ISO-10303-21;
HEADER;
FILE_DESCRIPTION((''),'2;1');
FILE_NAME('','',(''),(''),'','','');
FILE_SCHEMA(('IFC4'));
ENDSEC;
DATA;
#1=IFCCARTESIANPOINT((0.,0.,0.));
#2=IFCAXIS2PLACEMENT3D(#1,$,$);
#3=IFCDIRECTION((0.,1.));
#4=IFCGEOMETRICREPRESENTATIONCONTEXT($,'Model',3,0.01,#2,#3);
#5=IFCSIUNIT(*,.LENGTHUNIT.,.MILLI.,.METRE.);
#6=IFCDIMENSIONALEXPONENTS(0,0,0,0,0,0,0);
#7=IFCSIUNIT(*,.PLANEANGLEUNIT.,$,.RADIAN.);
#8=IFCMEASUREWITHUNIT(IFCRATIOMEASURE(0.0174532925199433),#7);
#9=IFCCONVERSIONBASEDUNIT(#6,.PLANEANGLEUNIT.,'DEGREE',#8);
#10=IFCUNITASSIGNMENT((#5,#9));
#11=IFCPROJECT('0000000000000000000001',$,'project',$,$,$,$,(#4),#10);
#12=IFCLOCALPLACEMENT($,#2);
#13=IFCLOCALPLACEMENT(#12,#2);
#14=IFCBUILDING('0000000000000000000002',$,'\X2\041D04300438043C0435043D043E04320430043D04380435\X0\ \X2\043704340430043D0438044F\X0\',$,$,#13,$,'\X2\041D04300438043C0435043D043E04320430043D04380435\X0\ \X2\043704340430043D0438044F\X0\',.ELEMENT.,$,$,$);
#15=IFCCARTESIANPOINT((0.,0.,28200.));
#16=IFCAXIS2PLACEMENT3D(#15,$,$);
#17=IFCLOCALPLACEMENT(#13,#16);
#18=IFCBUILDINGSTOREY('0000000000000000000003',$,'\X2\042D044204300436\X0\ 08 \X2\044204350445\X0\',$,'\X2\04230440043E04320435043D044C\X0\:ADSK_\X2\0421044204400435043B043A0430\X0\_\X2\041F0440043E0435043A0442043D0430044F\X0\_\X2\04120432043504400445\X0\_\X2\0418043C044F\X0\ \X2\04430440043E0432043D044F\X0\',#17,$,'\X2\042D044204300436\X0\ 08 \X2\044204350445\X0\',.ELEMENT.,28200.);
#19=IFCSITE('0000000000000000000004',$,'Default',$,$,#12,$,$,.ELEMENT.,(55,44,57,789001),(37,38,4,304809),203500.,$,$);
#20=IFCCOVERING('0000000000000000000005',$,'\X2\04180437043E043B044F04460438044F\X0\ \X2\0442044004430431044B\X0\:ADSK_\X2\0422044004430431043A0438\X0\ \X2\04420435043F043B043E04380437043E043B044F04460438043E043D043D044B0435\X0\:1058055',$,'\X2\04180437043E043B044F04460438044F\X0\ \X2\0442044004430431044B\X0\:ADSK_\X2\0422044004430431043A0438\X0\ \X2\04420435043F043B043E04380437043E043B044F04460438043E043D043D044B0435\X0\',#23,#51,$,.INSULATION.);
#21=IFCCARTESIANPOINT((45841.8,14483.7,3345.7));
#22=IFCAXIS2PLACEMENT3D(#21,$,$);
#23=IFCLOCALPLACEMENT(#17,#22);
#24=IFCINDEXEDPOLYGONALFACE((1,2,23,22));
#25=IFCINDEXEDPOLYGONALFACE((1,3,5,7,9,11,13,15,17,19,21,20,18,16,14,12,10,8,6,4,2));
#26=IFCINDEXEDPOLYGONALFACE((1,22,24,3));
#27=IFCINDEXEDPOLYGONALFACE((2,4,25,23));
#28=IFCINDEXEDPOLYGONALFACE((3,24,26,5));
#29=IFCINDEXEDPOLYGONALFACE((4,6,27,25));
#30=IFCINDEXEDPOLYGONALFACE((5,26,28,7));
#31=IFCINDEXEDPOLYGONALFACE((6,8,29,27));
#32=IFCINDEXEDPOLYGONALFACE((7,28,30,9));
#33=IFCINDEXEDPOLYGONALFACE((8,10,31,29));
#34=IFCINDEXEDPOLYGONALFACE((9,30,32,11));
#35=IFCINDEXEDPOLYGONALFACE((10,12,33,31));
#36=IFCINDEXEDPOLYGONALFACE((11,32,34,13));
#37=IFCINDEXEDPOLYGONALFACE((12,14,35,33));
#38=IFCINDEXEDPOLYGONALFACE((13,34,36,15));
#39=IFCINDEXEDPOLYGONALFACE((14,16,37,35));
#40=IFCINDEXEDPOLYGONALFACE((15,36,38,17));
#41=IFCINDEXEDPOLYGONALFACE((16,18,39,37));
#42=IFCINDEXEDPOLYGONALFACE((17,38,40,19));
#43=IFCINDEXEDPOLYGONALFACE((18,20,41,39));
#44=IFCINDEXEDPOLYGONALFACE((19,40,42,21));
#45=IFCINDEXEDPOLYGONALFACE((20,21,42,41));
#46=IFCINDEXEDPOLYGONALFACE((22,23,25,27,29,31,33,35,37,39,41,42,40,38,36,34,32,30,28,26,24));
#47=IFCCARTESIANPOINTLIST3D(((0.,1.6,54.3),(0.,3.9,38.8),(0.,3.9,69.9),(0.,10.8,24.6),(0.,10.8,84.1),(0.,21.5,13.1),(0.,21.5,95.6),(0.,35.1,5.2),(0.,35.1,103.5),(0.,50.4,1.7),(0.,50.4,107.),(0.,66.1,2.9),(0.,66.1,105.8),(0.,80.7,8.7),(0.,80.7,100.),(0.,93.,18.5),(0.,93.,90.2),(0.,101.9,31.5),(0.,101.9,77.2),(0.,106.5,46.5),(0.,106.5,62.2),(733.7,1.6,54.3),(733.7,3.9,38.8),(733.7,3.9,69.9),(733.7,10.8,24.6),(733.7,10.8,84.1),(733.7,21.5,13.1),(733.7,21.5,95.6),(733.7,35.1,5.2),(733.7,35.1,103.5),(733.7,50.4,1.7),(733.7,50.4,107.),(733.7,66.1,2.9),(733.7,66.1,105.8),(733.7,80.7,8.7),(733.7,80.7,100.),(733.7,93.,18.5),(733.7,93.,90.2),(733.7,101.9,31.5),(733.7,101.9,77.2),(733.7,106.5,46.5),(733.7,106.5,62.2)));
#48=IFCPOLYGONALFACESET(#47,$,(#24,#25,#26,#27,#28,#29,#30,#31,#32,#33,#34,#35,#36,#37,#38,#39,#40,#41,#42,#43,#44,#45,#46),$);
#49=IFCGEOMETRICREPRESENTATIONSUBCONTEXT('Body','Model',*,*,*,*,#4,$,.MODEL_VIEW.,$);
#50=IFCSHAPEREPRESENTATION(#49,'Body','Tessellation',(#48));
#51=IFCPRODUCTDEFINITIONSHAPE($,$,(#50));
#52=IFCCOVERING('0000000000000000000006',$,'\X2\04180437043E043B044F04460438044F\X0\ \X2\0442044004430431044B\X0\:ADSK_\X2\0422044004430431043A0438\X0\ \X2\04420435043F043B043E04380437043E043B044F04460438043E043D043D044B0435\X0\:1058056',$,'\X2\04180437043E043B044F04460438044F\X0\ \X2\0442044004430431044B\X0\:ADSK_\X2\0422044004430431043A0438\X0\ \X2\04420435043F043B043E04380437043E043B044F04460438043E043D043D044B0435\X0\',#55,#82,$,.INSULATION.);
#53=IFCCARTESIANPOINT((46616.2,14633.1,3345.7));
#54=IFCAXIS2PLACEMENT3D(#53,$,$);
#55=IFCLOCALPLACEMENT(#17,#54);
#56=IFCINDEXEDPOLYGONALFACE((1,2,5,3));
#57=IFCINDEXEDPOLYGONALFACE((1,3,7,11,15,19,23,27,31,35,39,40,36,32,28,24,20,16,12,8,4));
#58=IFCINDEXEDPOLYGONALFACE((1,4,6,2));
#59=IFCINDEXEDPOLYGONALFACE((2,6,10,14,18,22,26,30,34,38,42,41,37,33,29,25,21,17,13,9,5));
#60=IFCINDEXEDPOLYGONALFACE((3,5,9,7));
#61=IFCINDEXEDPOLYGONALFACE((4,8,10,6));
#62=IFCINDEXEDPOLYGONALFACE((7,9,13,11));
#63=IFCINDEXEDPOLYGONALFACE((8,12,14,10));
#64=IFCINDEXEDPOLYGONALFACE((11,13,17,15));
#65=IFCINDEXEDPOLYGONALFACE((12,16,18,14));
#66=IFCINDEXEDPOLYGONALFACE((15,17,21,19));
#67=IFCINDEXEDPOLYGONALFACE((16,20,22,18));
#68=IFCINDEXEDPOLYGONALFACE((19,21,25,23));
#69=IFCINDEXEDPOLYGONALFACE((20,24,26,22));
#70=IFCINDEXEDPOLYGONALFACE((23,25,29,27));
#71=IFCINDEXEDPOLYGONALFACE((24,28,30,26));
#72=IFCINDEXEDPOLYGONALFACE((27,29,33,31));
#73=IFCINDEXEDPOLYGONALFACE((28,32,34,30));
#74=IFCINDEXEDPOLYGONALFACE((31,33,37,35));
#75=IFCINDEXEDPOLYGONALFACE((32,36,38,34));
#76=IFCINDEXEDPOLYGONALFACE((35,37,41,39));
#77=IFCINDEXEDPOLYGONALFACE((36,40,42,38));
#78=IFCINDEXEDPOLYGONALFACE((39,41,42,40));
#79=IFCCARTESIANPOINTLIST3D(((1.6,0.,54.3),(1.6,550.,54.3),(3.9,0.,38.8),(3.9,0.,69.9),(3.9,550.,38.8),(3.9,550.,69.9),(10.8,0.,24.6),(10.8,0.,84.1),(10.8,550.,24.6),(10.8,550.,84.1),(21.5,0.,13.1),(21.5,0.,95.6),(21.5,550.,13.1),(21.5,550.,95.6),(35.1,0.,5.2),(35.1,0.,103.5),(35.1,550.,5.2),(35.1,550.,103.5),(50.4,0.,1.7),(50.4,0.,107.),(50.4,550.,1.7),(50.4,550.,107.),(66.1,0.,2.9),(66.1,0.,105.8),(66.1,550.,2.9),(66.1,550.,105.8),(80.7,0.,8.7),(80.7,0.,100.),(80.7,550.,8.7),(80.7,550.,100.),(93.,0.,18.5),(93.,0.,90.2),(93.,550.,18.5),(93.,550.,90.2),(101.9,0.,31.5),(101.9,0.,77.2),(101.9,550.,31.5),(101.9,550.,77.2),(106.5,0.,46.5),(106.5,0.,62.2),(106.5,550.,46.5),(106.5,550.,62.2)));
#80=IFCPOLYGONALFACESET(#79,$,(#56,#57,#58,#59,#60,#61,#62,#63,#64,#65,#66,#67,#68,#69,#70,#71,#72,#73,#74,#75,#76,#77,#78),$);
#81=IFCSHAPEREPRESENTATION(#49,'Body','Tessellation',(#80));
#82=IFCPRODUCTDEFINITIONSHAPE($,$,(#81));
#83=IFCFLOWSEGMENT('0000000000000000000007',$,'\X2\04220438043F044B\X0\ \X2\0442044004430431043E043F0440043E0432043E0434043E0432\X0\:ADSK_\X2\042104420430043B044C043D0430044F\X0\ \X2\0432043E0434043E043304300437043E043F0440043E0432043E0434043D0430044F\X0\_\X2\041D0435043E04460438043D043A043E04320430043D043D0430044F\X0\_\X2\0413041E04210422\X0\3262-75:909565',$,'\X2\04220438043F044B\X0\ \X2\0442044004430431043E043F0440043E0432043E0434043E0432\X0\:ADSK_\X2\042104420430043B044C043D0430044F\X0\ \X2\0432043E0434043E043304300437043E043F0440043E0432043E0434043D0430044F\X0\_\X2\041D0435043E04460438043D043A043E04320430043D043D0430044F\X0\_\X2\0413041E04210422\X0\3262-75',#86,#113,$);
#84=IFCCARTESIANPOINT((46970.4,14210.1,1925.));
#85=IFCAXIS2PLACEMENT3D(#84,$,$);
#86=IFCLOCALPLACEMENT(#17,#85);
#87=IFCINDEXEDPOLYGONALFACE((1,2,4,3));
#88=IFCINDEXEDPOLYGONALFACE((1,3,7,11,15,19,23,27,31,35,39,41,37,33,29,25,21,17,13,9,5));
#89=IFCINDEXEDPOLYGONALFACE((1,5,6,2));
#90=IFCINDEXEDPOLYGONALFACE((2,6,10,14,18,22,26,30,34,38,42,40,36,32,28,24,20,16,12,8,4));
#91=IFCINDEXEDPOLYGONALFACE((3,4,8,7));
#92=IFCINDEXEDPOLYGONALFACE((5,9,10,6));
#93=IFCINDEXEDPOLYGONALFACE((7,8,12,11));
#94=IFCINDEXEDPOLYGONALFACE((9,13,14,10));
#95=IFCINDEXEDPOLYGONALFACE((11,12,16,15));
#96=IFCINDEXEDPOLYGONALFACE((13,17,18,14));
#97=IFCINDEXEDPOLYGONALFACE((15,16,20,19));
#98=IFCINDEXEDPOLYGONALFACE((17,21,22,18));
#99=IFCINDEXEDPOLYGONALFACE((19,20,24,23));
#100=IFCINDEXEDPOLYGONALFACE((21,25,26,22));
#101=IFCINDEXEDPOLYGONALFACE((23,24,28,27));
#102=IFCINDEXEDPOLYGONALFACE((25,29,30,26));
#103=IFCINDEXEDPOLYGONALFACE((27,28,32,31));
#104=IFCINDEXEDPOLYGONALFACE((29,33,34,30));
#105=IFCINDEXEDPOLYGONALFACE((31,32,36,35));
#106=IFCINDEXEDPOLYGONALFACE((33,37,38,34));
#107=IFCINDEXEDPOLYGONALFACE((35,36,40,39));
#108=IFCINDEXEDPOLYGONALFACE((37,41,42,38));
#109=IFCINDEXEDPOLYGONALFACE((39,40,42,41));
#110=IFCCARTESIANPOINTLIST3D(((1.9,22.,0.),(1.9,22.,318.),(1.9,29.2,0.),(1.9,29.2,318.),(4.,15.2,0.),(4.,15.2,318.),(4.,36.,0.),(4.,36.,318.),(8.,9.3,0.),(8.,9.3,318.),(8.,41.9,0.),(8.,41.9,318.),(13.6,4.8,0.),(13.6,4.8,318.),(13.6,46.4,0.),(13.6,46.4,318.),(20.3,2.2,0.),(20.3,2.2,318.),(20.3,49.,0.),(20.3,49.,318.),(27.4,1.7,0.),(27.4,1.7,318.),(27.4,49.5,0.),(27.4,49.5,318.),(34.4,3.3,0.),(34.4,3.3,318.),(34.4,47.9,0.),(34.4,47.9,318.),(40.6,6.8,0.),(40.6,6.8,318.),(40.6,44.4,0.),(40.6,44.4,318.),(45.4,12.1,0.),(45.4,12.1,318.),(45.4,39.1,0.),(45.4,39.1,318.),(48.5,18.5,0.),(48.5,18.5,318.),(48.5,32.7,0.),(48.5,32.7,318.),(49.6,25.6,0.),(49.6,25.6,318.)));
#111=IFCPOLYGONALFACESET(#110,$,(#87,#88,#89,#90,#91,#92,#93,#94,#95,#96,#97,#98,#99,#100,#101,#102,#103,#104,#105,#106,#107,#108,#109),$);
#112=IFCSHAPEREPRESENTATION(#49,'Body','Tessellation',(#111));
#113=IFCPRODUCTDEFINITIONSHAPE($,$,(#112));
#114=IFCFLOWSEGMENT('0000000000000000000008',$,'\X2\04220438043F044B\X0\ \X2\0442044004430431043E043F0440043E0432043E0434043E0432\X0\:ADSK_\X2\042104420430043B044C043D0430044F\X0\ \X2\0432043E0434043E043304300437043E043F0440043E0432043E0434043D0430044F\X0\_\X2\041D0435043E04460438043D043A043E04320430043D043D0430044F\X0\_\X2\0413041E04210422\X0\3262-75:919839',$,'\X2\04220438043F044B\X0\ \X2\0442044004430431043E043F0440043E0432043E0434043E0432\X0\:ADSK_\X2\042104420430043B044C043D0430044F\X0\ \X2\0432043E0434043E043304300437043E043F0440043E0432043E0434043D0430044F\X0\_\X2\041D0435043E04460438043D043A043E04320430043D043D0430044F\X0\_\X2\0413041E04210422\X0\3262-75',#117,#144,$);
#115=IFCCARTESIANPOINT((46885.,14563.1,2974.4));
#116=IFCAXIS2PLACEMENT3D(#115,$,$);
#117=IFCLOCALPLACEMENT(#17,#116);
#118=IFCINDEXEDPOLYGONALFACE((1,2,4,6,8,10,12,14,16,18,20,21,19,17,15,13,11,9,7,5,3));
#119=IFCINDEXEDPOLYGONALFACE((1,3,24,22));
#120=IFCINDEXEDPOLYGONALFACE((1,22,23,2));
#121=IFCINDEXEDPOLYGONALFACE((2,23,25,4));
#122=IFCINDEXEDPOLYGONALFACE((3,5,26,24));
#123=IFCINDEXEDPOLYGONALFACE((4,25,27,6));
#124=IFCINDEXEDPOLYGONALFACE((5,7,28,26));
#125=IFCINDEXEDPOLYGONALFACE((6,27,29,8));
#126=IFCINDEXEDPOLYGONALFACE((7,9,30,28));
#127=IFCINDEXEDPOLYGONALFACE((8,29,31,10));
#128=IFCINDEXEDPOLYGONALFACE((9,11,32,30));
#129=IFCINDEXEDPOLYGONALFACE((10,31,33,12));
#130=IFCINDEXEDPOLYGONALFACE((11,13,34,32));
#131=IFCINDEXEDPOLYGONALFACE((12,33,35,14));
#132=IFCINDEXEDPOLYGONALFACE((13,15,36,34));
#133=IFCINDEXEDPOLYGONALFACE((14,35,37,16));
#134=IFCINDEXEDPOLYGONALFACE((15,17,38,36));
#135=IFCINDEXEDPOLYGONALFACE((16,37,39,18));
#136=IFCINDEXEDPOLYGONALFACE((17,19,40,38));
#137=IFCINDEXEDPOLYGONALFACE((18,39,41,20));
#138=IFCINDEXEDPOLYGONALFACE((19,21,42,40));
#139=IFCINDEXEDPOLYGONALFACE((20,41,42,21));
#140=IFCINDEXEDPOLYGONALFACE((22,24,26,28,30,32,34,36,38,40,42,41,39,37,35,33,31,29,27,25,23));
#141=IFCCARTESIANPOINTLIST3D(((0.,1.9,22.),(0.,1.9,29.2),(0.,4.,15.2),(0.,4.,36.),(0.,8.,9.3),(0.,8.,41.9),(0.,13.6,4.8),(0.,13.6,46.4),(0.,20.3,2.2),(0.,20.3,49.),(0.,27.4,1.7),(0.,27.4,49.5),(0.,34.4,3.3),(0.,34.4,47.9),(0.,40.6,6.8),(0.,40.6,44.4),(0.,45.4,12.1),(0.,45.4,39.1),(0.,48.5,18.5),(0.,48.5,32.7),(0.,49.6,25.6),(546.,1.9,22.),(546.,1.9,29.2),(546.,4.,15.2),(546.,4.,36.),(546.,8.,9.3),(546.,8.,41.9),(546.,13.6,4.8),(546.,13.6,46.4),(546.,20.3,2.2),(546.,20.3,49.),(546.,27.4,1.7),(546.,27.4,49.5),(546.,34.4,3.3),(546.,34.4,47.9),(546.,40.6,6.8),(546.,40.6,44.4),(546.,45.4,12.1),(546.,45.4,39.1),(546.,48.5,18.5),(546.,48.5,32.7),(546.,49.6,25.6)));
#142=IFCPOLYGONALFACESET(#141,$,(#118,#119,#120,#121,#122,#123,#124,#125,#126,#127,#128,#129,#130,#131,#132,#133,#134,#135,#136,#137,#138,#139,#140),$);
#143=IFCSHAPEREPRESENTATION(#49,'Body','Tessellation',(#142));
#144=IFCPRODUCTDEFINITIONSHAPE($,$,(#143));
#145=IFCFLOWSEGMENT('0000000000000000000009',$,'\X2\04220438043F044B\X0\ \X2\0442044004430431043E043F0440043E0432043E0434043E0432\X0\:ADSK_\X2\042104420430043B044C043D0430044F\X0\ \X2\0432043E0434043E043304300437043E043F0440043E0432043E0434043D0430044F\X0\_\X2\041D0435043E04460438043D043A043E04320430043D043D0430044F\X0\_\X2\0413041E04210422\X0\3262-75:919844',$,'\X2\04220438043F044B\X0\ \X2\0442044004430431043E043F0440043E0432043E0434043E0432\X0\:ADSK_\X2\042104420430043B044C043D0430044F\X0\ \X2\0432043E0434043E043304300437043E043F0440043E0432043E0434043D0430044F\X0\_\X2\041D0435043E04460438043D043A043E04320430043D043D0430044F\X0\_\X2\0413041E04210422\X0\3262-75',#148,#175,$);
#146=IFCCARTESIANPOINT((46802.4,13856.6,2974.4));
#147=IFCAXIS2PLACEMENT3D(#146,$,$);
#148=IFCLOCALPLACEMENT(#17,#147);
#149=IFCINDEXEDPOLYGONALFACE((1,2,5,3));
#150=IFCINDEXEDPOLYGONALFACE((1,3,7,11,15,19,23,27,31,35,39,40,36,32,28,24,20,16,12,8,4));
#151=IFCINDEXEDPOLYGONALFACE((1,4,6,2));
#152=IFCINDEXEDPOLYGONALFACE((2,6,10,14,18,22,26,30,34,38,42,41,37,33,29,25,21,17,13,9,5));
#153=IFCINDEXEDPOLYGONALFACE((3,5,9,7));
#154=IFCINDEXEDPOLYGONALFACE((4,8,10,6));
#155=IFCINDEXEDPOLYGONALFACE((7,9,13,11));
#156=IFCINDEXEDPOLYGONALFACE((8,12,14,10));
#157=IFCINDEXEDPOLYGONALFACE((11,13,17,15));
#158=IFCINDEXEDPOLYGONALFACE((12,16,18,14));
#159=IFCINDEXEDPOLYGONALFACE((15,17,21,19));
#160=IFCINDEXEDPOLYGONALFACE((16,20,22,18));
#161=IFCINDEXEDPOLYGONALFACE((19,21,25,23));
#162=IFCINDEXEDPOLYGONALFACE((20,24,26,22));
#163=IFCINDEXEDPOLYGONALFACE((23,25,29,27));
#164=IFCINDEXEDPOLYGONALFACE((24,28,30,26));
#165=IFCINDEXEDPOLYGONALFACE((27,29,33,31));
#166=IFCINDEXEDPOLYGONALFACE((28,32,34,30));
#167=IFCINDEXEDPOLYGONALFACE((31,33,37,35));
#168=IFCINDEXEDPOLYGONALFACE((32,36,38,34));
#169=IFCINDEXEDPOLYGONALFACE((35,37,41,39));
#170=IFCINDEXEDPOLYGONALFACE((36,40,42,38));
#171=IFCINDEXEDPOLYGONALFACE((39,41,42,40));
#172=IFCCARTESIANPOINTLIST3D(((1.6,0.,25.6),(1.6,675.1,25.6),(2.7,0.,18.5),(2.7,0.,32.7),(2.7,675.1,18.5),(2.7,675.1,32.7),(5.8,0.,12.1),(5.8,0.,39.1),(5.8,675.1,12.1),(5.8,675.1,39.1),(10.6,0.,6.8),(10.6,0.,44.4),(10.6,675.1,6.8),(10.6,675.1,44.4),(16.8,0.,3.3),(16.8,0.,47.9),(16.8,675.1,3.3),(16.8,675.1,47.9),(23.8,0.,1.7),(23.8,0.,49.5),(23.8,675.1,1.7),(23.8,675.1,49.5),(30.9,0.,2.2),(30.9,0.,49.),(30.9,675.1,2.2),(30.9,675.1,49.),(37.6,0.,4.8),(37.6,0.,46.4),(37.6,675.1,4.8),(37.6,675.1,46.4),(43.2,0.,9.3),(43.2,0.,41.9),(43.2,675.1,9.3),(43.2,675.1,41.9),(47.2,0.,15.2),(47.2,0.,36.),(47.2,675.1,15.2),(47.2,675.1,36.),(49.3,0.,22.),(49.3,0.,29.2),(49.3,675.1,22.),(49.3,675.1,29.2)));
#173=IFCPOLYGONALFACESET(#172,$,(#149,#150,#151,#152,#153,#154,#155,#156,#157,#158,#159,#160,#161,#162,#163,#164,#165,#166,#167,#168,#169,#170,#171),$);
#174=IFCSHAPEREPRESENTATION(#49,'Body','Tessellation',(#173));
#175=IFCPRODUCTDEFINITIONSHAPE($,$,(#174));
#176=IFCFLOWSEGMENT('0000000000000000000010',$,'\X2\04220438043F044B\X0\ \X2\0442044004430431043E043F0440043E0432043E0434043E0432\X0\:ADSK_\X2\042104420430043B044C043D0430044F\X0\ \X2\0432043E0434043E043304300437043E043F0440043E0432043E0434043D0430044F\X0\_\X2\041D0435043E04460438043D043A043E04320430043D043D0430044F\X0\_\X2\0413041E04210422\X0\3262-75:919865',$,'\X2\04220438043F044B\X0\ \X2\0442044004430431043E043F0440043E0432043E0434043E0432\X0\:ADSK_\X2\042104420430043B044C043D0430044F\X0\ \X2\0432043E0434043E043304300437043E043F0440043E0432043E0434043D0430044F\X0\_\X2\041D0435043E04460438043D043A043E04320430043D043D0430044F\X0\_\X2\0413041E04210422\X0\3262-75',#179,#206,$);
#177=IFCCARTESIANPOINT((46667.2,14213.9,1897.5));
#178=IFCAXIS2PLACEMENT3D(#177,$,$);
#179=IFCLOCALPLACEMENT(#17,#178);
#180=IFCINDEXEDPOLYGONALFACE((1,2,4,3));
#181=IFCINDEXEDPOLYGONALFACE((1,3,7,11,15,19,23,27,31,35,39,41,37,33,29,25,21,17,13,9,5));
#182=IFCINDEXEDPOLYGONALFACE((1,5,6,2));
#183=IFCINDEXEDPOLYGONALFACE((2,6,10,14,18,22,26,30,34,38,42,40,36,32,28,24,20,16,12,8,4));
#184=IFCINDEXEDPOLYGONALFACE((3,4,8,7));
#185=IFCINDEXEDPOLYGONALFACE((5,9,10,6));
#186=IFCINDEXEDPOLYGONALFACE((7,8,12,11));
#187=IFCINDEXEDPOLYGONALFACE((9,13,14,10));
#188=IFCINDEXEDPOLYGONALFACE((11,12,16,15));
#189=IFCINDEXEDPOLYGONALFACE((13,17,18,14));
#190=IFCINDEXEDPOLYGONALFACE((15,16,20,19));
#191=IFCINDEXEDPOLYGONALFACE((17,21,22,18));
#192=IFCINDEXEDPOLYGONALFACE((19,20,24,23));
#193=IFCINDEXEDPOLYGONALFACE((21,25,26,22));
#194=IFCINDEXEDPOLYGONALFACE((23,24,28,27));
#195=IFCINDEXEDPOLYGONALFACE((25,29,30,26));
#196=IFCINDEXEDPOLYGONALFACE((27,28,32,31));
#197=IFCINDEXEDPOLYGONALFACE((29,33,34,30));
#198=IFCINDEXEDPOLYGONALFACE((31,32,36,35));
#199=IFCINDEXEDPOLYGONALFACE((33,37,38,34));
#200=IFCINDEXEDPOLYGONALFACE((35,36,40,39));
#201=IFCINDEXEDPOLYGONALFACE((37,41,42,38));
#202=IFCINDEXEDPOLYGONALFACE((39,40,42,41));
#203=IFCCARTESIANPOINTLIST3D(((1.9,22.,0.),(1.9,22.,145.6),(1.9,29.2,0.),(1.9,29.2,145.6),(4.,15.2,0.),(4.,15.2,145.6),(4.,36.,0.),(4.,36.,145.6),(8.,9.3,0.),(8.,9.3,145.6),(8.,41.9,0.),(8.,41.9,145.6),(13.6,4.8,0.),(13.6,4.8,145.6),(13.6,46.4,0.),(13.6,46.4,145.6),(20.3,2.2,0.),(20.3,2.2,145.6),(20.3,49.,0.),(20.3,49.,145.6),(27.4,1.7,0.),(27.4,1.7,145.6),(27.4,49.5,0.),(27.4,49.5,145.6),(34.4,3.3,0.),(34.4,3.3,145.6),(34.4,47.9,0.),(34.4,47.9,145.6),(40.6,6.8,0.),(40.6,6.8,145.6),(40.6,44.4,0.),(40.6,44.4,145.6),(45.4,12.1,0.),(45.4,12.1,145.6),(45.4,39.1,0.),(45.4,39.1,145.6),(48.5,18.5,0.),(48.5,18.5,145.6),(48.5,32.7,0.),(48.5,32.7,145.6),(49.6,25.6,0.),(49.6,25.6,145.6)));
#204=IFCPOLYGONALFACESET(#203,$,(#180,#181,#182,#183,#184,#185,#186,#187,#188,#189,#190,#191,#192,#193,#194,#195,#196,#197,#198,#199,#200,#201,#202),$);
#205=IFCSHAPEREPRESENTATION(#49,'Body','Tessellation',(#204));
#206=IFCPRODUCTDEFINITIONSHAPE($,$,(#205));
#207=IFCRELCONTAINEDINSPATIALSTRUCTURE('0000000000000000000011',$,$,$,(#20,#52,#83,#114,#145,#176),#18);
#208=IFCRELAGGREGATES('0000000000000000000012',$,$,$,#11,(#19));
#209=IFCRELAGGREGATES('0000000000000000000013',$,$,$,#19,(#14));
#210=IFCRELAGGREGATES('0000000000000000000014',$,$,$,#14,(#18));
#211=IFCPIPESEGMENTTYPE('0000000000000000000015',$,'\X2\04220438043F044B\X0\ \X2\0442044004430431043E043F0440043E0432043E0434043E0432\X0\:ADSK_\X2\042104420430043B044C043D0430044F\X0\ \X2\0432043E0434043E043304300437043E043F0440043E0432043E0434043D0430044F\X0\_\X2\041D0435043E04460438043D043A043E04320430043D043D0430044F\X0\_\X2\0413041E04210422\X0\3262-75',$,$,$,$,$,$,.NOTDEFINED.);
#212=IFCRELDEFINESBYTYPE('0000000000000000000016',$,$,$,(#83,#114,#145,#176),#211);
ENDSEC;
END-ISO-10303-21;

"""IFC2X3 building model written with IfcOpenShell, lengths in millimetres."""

from ifc_helpers import new_model, entity, si_unit, converted_unit, direction, frame, origin, origin_2d_with_axis, place, context, subcontext, project, spatial, circle, extrude, type_object, element, save


model = new_model("IFC2X3")

# Units and contexts
model_context = context("Model", 3, precision=0.01, world=origin(), true_north=direction((0.0, 1.0)))
body_context = subcontext(model_context, "Body", "Model", "MODEL_VIEW")
ifc_project = project(units=[si_unit("LENGTHUNIT", "METRE", prefix="MILLI"), converted_unit("PLANEANGLEUNIT", "DEGREE", entity("IfcRatioMeasure", 0.0174532925199433), si_unit("PLANEANGLEUNIT", "RADIAN"), dimensions=[0, 0, 0, 0, 0, 0, 0])], contexts=[model_context])

# Site, building, storey
site_placement = place(None, origin())
site = spatial("IfcSite", under=ifc_project, at=site_placement, Name="Default", CompositionType="ELEMENT", RefLatitude=(55, 44, 57, 789001), RefLongitude=(37, 38, 4, 304809), RefElevation=203500.0)
building_placement = place(site_placement, origin())
building = spatial("IfcBuilding", under=site, at=building_placement, Name="Наименование здания", LongName="Наименование здания", CompositionType="ELEMENT")
storey_placement = place(building_placement, frame((0.0, 0.0, 28200.0)))
storey = spatial("IfcBuildingStorey", under=building, at=storey_placement, Name="Этаж 08 тех", ObjectType="Уровень:ADSK_Стрелка_Проектная_Вверх_Имя уровня", LongName="Этаж 08 тех", CompositionType="ELEMENT", Elevation=28200.0)

# Coverings
covering_1_placement = place(storey_placement, frame((45841.8, 14483.7, 3345.7)))
element("IfcCovering", 1, at=covering_1_placement, inside=storey, Name="Изоляция трубы:ADSK_Трубки теплоизоляционные:1058055", ObjectType="Изоляция трубы:ADSK_Трубки теплоизоляционные", PredefinedType="INSULATION", context=body_context, shape_type="SweptSolid", body=[
    extrude(circle(Radius=52.8, at=origin_2d_with_axis()), frame((0.0, 54.4, 54.4), z_axis=(1.0, 0.0, 0.0), x_axis=(0.0, -1.0, 0.0)), (0.0, 0.0, 1.0), 733.7),
])
covering_2_placement = place(storey_placement, frame((46616.2, 14633.1, 3345.7)))
element("IfcCovering", 2, at=covering_2_placement, inside=storey, Name="Изоляция трубы:ADSK_Трубки теплоизоляционные:1058056", ObjectType="Изоляция трубы:ADSK_Трубки теплоизоляционные", PredefinedType="INSULATION", context=body_context, shape_type="SweptSolid", body=[
    extrude(circle(Radius=52.8, at=origin_2d_with_axis()), frame((54.4, 0.0, 54.4), z_axis=(0.0, 1.0, 0.0), x_axis=(-1.0, 0.0, 0.0)), (0.0, 0.0, 1.0), 550.0),
])

# Flow segments
pipe_segment_type = type_object("IfcPipeSegmentType", Name="Типы трубопроводов:ADSK_Стальная водогазопроводная_Неоцинкованная_ГОСТ3262-75", PredefinedType="NOTDEFINED")
flow_segment_1_placement = place(storey_placement, frame((46970.4, 14210.1, 1925.0)))
element("IfcFlowSegment", 3, at=flow_segment_1_placement, inside=storey, type_object=pipe_segment_type, Name="Типы трубопроводов:ADSK_Стальная водогазопроводная_Неоцинкованная_ГОСТ3262-75:909565", ObjectType="Типы трубопроводов:ADSK_Стальная водогазопроводная_Неоцинкованная_ГОСТ3262-75", context=body_context, shape_type="SweptSolid", body=[
    extrude(circle(Radius=24.0, at=origin_2d_with_axis()), frame((25.6, 25.6, 0.0)), (0.0, 0.0, 1.0), 318.0),
])
flow_segment_2_placement = place(storey_placement, frame((46885.0, 14563.1, 2974.4)))
element("IfcFlowSegment", 4, at=flow_segment_2_placement, inside=storey, type_object=pipe_segment_type, Name="Типы трубопроводов:ADSK_Стальная водогазопроводная_Неоцинкованная_ГОСТ3262-75:919839", ObjectType="Типы трубопроводов:ADSK_Стальная водогазопроводная_Неоцинкованная_ГОСТ3262-75", context=body_context, shape_type="SweptSolid", body=[
    extrude(circle(Radius=24.0, at=origin_2d_with_axis()), frame((0.0, 25.6, 25.6), z_axis=(1.0, 0.0, 0.0), x_axis=(0.0, 1.0, 0.0)), (0.0, 0.0, 1.0), 546.0),
])
flow_segment_3_placement = place(storey_placement, frame((46802.4, 13856.6, 2974.4)))
element("IfcFlowSegment", 5, at=flow_segment_3_placement, inside=storey, type_object=pipe_segment_type, Name="Типы трубопроводов:ADSK_Стальная водогазопроводная_Неоцинкованная_ГОСТ3262-75:919844", ObjectType="Типы трубопроводов:ADSK_Стальная водогазопроводная_Неоцинкованная_ГОСТ3262-75", context=body_context, shape_type="SweptSolid", body=[
    extrude(circle(Radius=24.0, at=origin_2d_with_axis()), frame((25.6, 0.0, 25.6), z_axis=(0.0, 1.0, 0.0), x_axis=(-1.0, 0.0, 0.0)), (0.0, 0.0, 1.0), 675.1),
])
flow_segment_4_placement = place(storey_placement, frame((46667.2, 14213.9, 1897.5)))
element("IfcFlowSegment", 6, at=flow_segment_4_placement, inside=storey, type_object=pipe_segment_type, Name="Типы трубопроводов:ADSK_Стальная водогазопроводная_Неоцинкованная_ГОСТ3262-75:919865", ObjectType="Типы трубопроводов:ADSK_Стальная водогазопроводная_Неоцинкованная_ГОСТ3262-75", context=body_context, shape_type="SweptSolid", body=[
    extrude(circle(Radius=24.0, at=origin_2d_with_axis()), frame((25.6, 25.6, 0.0)), (0.0, 0.0, 1.0), 145.6),
])

save(model, "model.ifc")
